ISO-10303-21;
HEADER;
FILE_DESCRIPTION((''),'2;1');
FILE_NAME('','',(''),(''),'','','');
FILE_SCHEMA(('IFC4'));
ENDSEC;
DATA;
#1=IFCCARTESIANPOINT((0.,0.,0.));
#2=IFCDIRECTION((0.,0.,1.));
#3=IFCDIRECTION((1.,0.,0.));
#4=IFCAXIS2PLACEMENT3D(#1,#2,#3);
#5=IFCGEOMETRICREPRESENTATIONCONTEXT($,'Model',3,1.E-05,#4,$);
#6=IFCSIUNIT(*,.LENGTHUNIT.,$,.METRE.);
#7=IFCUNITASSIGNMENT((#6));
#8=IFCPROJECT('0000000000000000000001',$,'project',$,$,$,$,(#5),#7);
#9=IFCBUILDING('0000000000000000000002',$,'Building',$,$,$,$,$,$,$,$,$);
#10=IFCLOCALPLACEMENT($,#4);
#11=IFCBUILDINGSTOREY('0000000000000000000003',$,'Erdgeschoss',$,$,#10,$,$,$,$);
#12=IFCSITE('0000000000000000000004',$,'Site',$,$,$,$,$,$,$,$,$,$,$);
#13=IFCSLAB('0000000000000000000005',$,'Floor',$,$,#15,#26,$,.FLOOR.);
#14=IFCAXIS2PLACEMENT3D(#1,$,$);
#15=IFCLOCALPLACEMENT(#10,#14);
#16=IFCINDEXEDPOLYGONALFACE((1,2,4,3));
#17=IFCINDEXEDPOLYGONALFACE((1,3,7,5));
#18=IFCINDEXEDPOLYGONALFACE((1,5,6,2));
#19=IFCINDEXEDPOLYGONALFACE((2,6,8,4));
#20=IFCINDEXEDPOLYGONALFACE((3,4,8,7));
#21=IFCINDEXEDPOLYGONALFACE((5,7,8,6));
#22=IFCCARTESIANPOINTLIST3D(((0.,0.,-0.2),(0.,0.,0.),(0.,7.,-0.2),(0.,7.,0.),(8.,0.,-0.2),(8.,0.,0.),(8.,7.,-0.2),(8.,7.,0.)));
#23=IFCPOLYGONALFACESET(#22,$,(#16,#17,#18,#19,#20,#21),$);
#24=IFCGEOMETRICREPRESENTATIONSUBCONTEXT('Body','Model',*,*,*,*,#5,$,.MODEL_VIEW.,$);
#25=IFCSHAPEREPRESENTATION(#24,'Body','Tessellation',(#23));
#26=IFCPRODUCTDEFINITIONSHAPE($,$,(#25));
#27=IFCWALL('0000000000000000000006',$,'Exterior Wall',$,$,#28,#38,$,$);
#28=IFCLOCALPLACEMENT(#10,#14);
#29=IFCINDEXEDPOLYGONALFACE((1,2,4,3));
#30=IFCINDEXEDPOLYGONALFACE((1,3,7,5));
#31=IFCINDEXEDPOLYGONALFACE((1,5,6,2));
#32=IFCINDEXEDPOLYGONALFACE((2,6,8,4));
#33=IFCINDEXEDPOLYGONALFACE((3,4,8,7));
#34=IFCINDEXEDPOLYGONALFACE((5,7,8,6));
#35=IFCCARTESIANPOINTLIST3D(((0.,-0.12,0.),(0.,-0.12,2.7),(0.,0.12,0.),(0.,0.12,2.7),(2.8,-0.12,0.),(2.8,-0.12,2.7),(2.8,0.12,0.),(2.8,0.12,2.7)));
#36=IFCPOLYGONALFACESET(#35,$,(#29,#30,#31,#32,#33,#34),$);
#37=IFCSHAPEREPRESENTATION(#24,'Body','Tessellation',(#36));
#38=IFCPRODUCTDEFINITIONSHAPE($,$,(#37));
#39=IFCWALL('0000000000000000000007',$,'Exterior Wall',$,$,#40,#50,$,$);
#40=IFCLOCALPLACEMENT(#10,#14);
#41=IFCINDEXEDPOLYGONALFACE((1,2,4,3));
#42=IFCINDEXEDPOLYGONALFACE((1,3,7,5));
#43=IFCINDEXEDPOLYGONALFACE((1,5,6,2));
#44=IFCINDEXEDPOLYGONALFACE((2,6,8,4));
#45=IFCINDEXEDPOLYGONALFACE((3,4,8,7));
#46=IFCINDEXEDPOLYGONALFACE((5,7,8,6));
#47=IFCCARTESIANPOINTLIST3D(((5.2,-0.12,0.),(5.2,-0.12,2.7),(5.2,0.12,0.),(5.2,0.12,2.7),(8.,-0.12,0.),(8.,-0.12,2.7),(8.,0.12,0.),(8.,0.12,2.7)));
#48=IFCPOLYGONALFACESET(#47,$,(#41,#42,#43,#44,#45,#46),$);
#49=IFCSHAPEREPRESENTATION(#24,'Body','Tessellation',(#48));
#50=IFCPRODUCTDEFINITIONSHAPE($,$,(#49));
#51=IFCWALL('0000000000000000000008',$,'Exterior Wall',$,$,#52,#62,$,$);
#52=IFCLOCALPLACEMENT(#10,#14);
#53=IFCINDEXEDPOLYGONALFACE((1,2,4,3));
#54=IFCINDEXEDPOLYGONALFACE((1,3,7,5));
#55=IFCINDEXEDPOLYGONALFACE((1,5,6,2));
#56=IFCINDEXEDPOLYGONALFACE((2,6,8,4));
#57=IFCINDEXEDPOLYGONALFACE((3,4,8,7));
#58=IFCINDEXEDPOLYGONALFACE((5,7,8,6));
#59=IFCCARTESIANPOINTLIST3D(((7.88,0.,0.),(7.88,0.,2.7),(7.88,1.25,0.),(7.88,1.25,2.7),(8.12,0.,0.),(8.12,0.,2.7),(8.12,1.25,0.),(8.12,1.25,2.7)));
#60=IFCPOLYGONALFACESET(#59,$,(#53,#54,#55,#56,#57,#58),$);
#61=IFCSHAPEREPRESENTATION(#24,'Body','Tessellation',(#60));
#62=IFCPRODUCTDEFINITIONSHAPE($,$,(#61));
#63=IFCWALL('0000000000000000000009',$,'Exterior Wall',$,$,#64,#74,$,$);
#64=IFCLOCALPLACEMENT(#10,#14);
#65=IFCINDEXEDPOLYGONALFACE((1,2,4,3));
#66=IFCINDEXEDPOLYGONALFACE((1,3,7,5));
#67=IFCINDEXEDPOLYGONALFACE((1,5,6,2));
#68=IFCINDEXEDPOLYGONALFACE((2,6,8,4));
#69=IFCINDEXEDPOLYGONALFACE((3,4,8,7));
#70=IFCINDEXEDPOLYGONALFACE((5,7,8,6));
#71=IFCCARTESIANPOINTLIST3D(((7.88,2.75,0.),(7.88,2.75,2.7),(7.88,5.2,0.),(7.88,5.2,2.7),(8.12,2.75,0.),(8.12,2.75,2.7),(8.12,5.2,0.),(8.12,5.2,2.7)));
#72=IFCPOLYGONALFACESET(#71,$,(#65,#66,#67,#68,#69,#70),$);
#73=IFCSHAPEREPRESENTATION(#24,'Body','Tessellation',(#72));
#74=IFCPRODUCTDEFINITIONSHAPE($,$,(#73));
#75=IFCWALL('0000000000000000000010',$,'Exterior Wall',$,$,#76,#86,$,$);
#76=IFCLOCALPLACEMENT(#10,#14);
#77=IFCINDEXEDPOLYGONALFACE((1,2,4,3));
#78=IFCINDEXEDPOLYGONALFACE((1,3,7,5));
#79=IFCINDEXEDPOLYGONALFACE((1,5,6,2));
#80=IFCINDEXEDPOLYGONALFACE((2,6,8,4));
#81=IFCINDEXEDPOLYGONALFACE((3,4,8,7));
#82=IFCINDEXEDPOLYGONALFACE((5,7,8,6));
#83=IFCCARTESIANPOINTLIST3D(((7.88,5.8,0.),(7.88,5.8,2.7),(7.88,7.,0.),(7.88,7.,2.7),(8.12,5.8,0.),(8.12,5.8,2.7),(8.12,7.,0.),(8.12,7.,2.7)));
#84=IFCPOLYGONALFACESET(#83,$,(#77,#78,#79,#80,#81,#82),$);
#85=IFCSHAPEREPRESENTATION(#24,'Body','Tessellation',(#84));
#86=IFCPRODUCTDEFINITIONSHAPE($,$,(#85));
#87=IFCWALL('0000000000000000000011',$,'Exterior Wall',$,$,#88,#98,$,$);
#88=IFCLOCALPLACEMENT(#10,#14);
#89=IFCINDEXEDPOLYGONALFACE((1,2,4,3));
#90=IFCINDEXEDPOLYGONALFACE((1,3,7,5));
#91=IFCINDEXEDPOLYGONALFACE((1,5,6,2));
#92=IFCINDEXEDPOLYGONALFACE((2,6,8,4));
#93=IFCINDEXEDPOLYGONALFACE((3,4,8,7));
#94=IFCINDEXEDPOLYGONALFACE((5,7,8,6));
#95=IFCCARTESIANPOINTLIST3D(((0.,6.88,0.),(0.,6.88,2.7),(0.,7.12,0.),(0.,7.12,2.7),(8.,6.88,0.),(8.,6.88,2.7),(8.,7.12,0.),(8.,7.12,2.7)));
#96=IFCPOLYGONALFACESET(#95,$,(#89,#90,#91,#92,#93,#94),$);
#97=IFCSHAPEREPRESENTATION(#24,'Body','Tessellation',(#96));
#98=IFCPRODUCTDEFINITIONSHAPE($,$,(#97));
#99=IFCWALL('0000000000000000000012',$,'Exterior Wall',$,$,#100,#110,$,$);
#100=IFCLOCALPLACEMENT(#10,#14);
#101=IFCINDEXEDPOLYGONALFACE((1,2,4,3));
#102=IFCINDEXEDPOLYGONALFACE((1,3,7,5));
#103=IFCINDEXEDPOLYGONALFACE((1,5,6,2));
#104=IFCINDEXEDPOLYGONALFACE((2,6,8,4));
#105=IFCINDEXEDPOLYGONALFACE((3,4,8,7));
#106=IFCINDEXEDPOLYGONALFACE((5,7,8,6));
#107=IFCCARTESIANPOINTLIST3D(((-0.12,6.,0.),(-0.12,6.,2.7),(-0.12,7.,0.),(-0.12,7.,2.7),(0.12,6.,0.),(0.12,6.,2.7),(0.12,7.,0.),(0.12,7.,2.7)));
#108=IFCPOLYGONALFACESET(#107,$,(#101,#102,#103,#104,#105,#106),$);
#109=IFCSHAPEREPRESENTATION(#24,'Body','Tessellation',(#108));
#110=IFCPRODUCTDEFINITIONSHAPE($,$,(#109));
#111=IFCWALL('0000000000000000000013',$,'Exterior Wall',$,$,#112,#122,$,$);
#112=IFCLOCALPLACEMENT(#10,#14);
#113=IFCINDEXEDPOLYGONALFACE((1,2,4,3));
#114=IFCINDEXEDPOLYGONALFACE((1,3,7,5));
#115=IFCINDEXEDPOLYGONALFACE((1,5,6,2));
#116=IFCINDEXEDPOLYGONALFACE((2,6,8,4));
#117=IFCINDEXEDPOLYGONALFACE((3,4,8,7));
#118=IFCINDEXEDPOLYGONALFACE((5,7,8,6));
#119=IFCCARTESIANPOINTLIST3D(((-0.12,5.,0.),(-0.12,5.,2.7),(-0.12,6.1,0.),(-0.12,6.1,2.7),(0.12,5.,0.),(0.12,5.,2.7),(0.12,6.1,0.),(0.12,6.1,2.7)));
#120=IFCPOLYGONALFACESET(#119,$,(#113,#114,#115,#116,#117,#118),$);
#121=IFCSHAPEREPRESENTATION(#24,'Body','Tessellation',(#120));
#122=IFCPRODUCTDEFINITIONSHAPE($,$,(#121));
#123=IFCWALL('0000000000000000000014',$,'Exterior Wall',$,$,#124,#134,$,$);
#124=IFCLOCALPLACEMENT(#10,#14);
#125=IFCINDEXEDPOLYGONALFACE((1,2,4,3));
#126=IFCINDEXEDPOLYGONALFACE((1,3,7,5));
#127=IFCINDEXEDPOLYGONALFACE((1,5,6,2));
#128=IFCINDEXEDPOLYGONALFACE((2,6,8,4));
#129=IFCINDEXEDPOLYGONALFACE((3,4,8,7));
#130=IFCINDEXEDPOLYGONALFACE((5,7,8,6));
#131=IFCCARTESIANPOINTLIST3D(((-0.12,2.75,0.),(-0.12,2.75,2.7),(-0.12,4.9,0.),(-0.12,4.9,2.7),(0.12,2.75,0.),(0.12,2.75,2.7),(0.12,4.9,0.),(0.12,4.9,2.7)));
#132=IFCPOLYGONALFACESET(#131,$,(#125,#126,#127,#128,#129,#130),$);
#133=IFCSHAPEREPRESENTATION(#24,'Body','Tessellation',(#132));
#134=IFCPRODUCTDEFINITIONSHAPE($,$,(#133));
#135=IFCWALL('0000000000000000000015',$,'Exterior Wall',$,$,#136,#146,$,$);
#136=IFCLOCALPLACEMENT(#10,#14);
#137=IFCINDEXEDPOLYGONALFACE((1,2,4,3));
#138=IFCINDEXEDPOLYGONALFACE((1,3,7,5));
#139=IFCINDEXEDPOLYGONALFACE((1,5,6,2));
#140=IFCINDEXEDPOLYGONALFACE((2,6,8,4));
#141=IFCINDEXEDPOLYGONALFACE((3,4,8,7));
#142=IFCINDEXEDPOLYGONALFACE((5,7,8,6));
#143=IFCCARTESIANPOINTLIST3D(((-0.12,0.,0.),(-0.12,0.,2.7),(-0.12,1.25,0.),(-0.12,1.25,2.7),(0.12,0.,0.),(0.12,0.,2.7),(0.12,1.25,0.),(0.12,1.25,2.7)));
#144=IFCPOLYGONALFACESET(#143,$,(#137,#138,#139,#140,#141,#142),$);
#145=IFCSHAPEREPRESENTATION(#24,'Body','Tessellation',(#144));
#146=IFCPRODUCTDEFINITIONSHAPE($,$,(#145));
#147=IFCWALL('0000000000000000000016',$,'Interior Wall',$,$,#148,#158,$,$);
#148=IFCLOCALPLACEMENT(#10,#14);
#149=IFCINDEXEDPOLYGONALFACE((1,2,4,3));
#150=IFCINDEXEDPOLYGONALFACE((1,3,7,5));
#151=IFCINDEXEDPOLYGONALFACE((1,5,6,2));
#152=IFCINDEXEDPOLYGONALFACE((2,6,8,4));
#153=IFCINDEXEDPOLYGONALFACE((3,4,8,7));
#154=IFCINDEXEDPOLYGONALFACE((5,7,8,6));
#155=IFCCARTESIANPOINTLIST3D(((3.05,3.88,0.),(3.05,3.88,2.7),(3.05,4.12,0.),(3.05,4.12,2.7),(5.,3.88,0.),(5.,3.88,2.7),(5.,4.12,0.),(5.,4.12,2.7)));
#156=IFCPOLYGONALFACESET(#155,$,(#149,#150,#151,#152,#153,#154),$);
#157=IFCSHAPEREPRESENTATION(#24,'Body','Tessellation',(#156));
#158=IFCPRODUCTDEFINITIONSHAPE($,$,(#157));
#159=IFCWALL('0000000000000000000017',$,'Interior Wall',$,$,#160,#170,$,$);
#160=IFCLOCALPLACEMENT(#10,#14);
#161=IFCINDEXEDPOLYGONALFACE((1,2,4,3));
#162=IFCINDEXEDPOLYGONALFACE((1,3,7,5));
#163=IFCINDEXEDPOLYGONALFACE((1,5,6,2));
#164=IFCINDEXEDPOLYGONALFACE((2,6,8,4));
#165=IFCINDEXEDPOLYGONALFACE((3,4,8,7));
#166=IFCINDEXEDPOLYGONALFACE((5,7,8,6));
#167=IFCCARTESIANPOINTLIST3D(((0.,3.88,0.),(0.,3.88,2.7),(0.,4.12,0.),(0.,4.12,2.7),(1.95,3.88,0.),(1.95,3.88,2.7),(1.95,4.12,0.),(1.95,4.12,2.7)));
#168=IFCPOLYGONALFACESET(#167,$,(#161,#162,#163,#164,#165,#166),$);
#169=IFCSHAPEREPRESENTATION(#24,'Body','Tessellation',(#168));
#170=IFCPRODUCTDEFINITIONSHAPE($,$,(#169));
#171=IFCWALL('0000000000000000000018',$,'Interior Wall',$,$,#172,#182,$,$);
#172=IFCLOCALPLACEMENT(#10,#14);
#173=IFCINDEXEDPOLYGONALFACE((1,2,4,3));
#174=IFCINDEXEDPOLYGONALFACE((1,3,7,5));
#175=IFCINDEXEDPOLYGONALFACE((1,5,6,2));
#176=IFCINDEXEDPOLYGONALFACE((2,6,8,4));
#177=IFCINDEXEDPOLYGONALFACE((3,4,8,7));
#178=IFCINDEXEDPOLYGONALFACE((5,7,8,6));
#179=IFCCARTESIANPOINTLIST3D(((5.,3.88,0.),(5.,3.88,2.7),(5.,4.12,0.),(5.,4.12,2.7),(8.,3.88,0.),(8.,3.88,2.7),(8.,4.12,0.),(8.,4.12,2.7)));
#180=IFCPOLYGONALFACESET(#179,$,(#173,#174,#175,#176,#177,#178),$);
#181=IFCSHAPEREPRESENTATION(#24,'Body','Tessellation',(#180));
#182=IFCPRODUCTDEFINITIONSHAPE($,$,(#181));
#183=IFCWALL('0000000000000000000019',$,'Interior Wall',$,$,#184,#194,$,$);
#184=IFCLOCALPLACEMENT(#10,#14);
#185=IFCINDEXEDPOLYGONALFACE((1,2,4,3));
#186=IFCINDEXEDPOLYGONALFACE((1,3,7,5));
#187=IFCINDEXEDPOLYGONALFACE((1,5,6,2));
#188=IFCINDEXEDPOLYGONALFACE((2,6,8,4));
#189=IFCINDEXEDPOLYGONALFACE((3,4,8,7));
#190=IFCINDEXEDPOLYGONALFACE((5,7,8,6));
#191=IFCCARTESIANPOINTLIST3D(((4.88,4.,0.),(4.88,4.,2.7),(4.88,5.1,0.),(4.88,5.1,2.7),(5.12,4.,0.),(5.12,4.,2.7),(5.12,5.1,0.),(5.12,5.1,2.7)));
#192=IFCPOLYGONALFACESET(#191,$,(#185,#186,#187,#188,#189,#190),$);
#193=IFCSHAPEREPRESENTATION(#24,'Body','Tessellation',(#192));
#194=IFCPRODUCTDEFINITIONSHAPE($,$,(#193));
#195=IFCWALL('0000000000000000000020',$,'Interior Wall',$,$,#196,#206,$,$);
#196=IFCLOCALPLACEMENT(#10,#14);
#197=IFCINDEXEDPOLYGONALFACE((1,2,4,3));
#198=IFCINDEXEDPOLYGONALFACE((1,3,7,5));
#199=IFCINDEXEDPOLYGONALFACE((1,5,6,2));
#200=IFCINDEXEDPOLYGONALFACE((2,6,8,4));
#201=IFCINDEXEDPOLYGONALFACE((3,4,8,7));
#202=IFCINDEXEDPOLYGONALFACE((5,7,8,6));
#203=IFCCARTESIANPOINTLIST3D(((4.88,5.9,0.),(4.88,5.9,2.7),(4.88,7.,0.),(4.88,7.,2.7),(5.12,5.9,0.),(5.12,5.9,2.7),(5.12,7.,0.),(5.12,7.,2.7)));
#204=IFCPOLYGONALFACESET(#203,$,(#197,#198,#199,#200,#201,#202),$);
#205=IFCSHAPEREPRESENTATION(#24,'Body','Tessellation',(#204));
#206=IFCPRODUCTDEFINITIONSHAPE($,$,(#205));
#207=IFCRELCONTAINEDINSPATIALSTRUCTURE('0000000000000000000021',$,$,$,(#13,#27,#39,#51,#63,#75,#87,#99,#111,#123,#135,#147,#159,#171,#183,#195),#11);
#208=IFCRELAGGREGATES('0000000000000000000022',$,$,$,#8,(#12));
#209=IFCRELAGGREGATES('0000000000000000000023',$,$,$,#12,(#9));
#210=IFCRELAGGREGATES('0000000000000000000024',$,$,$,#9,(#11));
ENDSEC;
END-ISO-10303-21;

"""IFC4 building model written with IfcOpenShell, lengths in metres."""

from ifc_helpers import new_model, si_unit, frame, origin_with_axes, place, context, subcontext, project, spatial, indexed_curve, outline, extrude, element, save


model = new_model("IFC4")

# Units and contexts
model_context = context("Model", 3, precision=1e-05, world=origin_with_axes())
body_context = subcontext(model_context, "Body", "Model", "MODEL_VIEW")
ifc_project = project(units=[si_unit("LENGTHUNIT", "METRE")], contexts=[model_context])

# Site, building, storey
site = spatial("IfcSite", under=ifc_project, Name="Site")
building = spatial("IfcBuilding", under=site, Name="Building")
storey_placement = place(None, origin_with_axes())
storey = spatial("IfcBuildingStorey", under=building, at=storey_placement, Name="Erdgeschoss")

# Slab
slab_placement = place(storey_placement, frame((0.0, 0.0, -0.2), z_axis=(0.0, 0.0, 1.0), x_axis=(1.0, 0.0, 0.0)))
element("IfcSlab", 1, at=slab_placement, inside=storey, Name="Floor", PredefinedType="FLOOR", context=body_context, shape_type="SweptSolid", body=[
    extrude(outline(indexed_curve([(0.0, 0.0), (8.0, 0.0), (8.0, 7.0), (0.0, 7.0)])), None, (0.0, 0.0, 1.0), 0.2),
])

# Walls
for number, where, z_axis, x_axis, name in (
    (2, (0.0, 0.0, 0.0), (0.0, 0.0, 1.0), (1.0, 0.0, 0.0), "Exterior Wall"),
    (3, (5.2, 0.0, 0.0), (0.0, 0.0, 1.0), (1.0, 0.0, 0.0), "Exterior Wall"),
):
    element("IfcWall", number, at=place(storey_placement, frame(where, z_axis=z_axis, x_axis=x_axis)), inside=storey, Name=name, context=body_context, shape_type="SweptSolid", body=[
        extrude(outline(indexed_curve([(0.0, 0.0), (0.0, 0.24), (2.8, 0.24), (2.8, 0.0), (0.0, 0.0)], self_intersect=False)), frame((0.0, -0.12, 0.0), z_axis=(0.0, 0.0, 1.0), x_axis=(1.0, 0.0, 0.0)), (0.0, 0.0, 1.0), 2.7),
    ])
wall_1_placement = place(storey_placement, frame((8.0, 0.0, 0.0), z_axis=(0.0, 0.0, 1.0), x_axis=(0.0, 1.0, 0.0)))
element("IfcWall", 4, at=wall_1_placement, inside=storey, Name="Exterior Wall", context=body_context, shape_type="SweptSolid", body=[
    extrude(outline(indexed_curve([(0.0, 0.0), (0.0, 0.24), (1.25, 0.24), (1.25, 0.0), (0.0, 0.0)], self_intersect=False)), frame((0.0, -0.12, 0.0), z_axis=(0.0, 0.0, 1.0), x_axis=(1.0, 0.0, 0.0)), (0.0, 0.0, 1.0), 2.7),
])
wall_2_placement = place(storey_placement, frame((8.0, 2.75, 0.0), z_axis=(0.0, 0.0, 1.0), x_axis=(0.0, 1.0, 0.0)))
element("IfcWall", 5, at=wall_2_placement, inside=storey, Name="Exterior Wall", context=body_context, shape_type="SweptSolid", body=[
    extrude(outline(indexed_curve([(0.0, 0.0), (0.0, 0.24), (2.45, 0.24), (2.45, 0.0), (0.0, 0.0)], self_intersect=False)), frame((0.0, -0.12, 0.0), z_axis=(0.0, 0.0, 1.0), x_axis=(1.0, 0.0, 0.0)), (0.0, 0.0, 1.0), 2.7),
])
wall_3_placement = place(storey_placement, frame((8.0, 5.8, 0.0), z_axis=(0.0, 0.0, 1.0), x_axis=(0.0, 1.0, 0.0)))
element("IfcWall", 6, at=wall_3_placement, inside=storey, Name="Exterior Wall", context=body_context, shape_type="SweptSolid", body=[
    extrude(outline(indexed_curve([(0.0, 0.0), (0.0, 0.24), (1.2, 0.24), (1.2, 0.0), (0.0, 0.0)], self_intersect=False)), frame((0.0, -0.12, 0.0), z_axis=(0.0, 0.0, 1.0), x_axis=(1.0, 0.0, 0.0)), (0.0, 0.0, 1.0), 2.7),
])
wall_4_placement = place(storey_placement, frame((8.0, 7.0, 0.0), z_axis=(0.0, 0.0, 1.0), x_axis=(-1.0, 0.0, 0.0)))
element("IfcWall", 7, at=wall_4_placement, inside=storey, Name="Exterior Wall", context=body_context, shape_type="SweptSolid", body=[
    extrude(outline(indexed_curve([(0.0, 0.0), (0.0, 0.24), (8.0, 0.24), (8.0, 0.0), (0.0, 0.0)], self_intersect=False)), frame((0.0, -0.12, 0.0), z_axis=(0.0, 0.0, 1.0), x_axis=(1.0, 0.0, 0.0)), (0.0, 0.0, 1.0), 2.7),
])
wall_5_placement = place(storey_placement, frame((0.0, 7.0, 0.0), z_axis=(0.0, 0.0, 1.0), x_axis=(0.0, -1.0, 0.0)))
element("IfcWall", 8, at=wall_5_placement, inside=storey, Name="Exterior Wall", context=body_context, shape_type="SweptSolid", body=[
    extrude(outline(indexed_curve([(0.0, 0.0), (0.0, 0.24), (1.0, 0.24), (1.0, 0.0), (0.0, 0.0)], self_intersect=False)), frame((0.0, -0.12, 0.0), z_axis=(0.0, 0.0, 1.0), x_axis=(1.0, 0.0, 0.0)), (0.0, 0.0, 1.0), 2.7),
])
wall_6_placement = place(storey_placement, frame((0.0, 5.0, 0.0), z_axis=(0.0, 0.0, 1.0), x_axis=(0.0, 1.0, 0.0)))
element("IfcWall", 9, at=wall_6_placement, inside=storey, Name="Exterior Wall", context=body_context, shape_type="SweptSolid", body=[
    extrude(outline(indexed_curve([(0.0, 0.0), (0.0, 0.24), (1.1, 0.24), (1.1, 0.0), (0.0, 0.0)], self_intersect=False)), frame((0.0, -0.12, 0.0), z_axis=(0.0, 0.0, 1.0), x_axis=(1.0, 0.0, 0.0)), (0.0, 0.0, 1.0), 2.7),
])
wall_7_placement = place(storey_placement, frame((0.0, 4.9, 0.0), z_axis=(0.0, 0.0, 1.0), x_axis=(0.0, -1.0, 0.0)))
element("IfcWall", 10, at=wall_7_placement, inside=storey, Name="Exterior Wall", context=body_context, shape_type="SweptSolid", body=[
    extrude(outline(indexed_curve([(0.0, 0.0), (0.0, 0.24), (2.15, 0.24), (2.15, 0.0), (0.0, 0.0)], self_intersect=False)), frame((0.0, -0.12, 0.0), z_axis=(0.0, 0.0, 1.0), x_axis=(1.0, 0.0, 0.0)), (0.0, 0.0, 1.0), 2.7),
])
wall_8_placement = place(storey_placement, frame((0.0, 1.25, 0.0), z_axis=(0.0, 0.0, 1.0), x_axis=(0.0, -1.0, 0.0)))
element("IfcWall", 11, at=wall_8_placement, inside=storey, Name="Exterior Wall", context=body_context, shape_type="SweptSolid", body=[
    extrude(outline(indexed_curve([(0.0, 0.0), (0.0, 0.24), (1.25, 0.24), (1.25, 0.0), (0.0, 0.0)], self_intersect=False)), frame((0.0, -0.12, 0.0), z_axis=(0.0, 0.0, 1.0), x_axis=(1.0, 0.0, 0.0)), (0.0, 0.0, 1.0), 2.7),
])
for number, where, z_axis, x_axis, name in (
    (12, (5.0, 4.0, 0.0), (0.0, 0.0, 1.0), (-1.0, 0.0, 0.0), "Interior Wall"),
    (13, (1.95, 4.0, 0.0), (0.0, 0.0, 1.0), (-1.0, 0.0, 0.0), "Interior Wall"),
):
    element("IfcWall", number, at=place(storey_placement, frame(where, z_axis=z_axis, x_axis=x_axis)), inside=storey, Name=name, context=body_context, shape_type="SweptSolid", body=[
        extrude(outline(indexed_curve([(0.0, 0.0), (0.0, 0.24), (1.95, 0.24), (1.95, 0.0), (0.0, 0.0)], self_intersect=False)), frame((0.0, -0.12, 0.0), z_axis=(0.0, 0.0, 1.0), x_axis=(1.0, 0.0, 0.0)), (0.0, 0.0, 1.0), 2.7),
    ])
wall_9_placement = place(storey_placement, frame((8.0, 4.0, 0.0), z_axis=(0.0, 0.0, 1.0), x_axis=(-1.0, 0.0, 0.0)))
element("IfcWall", 14, at=wall_9_placement, inside=storey, Name="Interior Wall", context=body_context, shape_type="SweptSolid", body=[
    extrude(outline(indexed_curve([(0.0, 0.0), (0.0, 0.24), (3.0, 0.24), (3.0, 0.0), (0.0, 0.0)], self_intersect=False)), frame((0.0, -0.12, 0.0), z_axis=(0.0, 0.0, 1.0), x_axis=(1.0, 0.0, 0.0)), (0.0, 0.0, 1.0), 2.7),
])
for number, where, z_axis, x_axis, name in (
    (15, (5.0, 4.0, 0.0), (0.0, 0.0, 1.0), (0.0, 1.0, 0.0), "Interior Wall"),
    (16, (5.0, 5.9, 0.0), (0.0, 0.0, 1.0), (0.0, 1.0, 0.0), "Interior Wall"),
):
    element("IfcWall", number, at=place(storey_placement, frame(where, z_axis=z_axis, x_axis=x_axis)), inside=storey, Name=name, context=body_context, shape_type="SweptSolid", body=[
        extrude(outline(indexed_curve([(0.0, 0.0), (0.0, 0.24), (1.1, 0.24), (1.1, 0.0), (0.0, 0.0)], self_intersect=False)), frame((0.0, -0.12, 0.0), z_axis=(0.0, 0.0, 1.0), x_axis=(1.0, 0.0, 0.0)), (0.0, 0.0, 1.0), 2.7),
    ])

save(model, "model.ifc")
